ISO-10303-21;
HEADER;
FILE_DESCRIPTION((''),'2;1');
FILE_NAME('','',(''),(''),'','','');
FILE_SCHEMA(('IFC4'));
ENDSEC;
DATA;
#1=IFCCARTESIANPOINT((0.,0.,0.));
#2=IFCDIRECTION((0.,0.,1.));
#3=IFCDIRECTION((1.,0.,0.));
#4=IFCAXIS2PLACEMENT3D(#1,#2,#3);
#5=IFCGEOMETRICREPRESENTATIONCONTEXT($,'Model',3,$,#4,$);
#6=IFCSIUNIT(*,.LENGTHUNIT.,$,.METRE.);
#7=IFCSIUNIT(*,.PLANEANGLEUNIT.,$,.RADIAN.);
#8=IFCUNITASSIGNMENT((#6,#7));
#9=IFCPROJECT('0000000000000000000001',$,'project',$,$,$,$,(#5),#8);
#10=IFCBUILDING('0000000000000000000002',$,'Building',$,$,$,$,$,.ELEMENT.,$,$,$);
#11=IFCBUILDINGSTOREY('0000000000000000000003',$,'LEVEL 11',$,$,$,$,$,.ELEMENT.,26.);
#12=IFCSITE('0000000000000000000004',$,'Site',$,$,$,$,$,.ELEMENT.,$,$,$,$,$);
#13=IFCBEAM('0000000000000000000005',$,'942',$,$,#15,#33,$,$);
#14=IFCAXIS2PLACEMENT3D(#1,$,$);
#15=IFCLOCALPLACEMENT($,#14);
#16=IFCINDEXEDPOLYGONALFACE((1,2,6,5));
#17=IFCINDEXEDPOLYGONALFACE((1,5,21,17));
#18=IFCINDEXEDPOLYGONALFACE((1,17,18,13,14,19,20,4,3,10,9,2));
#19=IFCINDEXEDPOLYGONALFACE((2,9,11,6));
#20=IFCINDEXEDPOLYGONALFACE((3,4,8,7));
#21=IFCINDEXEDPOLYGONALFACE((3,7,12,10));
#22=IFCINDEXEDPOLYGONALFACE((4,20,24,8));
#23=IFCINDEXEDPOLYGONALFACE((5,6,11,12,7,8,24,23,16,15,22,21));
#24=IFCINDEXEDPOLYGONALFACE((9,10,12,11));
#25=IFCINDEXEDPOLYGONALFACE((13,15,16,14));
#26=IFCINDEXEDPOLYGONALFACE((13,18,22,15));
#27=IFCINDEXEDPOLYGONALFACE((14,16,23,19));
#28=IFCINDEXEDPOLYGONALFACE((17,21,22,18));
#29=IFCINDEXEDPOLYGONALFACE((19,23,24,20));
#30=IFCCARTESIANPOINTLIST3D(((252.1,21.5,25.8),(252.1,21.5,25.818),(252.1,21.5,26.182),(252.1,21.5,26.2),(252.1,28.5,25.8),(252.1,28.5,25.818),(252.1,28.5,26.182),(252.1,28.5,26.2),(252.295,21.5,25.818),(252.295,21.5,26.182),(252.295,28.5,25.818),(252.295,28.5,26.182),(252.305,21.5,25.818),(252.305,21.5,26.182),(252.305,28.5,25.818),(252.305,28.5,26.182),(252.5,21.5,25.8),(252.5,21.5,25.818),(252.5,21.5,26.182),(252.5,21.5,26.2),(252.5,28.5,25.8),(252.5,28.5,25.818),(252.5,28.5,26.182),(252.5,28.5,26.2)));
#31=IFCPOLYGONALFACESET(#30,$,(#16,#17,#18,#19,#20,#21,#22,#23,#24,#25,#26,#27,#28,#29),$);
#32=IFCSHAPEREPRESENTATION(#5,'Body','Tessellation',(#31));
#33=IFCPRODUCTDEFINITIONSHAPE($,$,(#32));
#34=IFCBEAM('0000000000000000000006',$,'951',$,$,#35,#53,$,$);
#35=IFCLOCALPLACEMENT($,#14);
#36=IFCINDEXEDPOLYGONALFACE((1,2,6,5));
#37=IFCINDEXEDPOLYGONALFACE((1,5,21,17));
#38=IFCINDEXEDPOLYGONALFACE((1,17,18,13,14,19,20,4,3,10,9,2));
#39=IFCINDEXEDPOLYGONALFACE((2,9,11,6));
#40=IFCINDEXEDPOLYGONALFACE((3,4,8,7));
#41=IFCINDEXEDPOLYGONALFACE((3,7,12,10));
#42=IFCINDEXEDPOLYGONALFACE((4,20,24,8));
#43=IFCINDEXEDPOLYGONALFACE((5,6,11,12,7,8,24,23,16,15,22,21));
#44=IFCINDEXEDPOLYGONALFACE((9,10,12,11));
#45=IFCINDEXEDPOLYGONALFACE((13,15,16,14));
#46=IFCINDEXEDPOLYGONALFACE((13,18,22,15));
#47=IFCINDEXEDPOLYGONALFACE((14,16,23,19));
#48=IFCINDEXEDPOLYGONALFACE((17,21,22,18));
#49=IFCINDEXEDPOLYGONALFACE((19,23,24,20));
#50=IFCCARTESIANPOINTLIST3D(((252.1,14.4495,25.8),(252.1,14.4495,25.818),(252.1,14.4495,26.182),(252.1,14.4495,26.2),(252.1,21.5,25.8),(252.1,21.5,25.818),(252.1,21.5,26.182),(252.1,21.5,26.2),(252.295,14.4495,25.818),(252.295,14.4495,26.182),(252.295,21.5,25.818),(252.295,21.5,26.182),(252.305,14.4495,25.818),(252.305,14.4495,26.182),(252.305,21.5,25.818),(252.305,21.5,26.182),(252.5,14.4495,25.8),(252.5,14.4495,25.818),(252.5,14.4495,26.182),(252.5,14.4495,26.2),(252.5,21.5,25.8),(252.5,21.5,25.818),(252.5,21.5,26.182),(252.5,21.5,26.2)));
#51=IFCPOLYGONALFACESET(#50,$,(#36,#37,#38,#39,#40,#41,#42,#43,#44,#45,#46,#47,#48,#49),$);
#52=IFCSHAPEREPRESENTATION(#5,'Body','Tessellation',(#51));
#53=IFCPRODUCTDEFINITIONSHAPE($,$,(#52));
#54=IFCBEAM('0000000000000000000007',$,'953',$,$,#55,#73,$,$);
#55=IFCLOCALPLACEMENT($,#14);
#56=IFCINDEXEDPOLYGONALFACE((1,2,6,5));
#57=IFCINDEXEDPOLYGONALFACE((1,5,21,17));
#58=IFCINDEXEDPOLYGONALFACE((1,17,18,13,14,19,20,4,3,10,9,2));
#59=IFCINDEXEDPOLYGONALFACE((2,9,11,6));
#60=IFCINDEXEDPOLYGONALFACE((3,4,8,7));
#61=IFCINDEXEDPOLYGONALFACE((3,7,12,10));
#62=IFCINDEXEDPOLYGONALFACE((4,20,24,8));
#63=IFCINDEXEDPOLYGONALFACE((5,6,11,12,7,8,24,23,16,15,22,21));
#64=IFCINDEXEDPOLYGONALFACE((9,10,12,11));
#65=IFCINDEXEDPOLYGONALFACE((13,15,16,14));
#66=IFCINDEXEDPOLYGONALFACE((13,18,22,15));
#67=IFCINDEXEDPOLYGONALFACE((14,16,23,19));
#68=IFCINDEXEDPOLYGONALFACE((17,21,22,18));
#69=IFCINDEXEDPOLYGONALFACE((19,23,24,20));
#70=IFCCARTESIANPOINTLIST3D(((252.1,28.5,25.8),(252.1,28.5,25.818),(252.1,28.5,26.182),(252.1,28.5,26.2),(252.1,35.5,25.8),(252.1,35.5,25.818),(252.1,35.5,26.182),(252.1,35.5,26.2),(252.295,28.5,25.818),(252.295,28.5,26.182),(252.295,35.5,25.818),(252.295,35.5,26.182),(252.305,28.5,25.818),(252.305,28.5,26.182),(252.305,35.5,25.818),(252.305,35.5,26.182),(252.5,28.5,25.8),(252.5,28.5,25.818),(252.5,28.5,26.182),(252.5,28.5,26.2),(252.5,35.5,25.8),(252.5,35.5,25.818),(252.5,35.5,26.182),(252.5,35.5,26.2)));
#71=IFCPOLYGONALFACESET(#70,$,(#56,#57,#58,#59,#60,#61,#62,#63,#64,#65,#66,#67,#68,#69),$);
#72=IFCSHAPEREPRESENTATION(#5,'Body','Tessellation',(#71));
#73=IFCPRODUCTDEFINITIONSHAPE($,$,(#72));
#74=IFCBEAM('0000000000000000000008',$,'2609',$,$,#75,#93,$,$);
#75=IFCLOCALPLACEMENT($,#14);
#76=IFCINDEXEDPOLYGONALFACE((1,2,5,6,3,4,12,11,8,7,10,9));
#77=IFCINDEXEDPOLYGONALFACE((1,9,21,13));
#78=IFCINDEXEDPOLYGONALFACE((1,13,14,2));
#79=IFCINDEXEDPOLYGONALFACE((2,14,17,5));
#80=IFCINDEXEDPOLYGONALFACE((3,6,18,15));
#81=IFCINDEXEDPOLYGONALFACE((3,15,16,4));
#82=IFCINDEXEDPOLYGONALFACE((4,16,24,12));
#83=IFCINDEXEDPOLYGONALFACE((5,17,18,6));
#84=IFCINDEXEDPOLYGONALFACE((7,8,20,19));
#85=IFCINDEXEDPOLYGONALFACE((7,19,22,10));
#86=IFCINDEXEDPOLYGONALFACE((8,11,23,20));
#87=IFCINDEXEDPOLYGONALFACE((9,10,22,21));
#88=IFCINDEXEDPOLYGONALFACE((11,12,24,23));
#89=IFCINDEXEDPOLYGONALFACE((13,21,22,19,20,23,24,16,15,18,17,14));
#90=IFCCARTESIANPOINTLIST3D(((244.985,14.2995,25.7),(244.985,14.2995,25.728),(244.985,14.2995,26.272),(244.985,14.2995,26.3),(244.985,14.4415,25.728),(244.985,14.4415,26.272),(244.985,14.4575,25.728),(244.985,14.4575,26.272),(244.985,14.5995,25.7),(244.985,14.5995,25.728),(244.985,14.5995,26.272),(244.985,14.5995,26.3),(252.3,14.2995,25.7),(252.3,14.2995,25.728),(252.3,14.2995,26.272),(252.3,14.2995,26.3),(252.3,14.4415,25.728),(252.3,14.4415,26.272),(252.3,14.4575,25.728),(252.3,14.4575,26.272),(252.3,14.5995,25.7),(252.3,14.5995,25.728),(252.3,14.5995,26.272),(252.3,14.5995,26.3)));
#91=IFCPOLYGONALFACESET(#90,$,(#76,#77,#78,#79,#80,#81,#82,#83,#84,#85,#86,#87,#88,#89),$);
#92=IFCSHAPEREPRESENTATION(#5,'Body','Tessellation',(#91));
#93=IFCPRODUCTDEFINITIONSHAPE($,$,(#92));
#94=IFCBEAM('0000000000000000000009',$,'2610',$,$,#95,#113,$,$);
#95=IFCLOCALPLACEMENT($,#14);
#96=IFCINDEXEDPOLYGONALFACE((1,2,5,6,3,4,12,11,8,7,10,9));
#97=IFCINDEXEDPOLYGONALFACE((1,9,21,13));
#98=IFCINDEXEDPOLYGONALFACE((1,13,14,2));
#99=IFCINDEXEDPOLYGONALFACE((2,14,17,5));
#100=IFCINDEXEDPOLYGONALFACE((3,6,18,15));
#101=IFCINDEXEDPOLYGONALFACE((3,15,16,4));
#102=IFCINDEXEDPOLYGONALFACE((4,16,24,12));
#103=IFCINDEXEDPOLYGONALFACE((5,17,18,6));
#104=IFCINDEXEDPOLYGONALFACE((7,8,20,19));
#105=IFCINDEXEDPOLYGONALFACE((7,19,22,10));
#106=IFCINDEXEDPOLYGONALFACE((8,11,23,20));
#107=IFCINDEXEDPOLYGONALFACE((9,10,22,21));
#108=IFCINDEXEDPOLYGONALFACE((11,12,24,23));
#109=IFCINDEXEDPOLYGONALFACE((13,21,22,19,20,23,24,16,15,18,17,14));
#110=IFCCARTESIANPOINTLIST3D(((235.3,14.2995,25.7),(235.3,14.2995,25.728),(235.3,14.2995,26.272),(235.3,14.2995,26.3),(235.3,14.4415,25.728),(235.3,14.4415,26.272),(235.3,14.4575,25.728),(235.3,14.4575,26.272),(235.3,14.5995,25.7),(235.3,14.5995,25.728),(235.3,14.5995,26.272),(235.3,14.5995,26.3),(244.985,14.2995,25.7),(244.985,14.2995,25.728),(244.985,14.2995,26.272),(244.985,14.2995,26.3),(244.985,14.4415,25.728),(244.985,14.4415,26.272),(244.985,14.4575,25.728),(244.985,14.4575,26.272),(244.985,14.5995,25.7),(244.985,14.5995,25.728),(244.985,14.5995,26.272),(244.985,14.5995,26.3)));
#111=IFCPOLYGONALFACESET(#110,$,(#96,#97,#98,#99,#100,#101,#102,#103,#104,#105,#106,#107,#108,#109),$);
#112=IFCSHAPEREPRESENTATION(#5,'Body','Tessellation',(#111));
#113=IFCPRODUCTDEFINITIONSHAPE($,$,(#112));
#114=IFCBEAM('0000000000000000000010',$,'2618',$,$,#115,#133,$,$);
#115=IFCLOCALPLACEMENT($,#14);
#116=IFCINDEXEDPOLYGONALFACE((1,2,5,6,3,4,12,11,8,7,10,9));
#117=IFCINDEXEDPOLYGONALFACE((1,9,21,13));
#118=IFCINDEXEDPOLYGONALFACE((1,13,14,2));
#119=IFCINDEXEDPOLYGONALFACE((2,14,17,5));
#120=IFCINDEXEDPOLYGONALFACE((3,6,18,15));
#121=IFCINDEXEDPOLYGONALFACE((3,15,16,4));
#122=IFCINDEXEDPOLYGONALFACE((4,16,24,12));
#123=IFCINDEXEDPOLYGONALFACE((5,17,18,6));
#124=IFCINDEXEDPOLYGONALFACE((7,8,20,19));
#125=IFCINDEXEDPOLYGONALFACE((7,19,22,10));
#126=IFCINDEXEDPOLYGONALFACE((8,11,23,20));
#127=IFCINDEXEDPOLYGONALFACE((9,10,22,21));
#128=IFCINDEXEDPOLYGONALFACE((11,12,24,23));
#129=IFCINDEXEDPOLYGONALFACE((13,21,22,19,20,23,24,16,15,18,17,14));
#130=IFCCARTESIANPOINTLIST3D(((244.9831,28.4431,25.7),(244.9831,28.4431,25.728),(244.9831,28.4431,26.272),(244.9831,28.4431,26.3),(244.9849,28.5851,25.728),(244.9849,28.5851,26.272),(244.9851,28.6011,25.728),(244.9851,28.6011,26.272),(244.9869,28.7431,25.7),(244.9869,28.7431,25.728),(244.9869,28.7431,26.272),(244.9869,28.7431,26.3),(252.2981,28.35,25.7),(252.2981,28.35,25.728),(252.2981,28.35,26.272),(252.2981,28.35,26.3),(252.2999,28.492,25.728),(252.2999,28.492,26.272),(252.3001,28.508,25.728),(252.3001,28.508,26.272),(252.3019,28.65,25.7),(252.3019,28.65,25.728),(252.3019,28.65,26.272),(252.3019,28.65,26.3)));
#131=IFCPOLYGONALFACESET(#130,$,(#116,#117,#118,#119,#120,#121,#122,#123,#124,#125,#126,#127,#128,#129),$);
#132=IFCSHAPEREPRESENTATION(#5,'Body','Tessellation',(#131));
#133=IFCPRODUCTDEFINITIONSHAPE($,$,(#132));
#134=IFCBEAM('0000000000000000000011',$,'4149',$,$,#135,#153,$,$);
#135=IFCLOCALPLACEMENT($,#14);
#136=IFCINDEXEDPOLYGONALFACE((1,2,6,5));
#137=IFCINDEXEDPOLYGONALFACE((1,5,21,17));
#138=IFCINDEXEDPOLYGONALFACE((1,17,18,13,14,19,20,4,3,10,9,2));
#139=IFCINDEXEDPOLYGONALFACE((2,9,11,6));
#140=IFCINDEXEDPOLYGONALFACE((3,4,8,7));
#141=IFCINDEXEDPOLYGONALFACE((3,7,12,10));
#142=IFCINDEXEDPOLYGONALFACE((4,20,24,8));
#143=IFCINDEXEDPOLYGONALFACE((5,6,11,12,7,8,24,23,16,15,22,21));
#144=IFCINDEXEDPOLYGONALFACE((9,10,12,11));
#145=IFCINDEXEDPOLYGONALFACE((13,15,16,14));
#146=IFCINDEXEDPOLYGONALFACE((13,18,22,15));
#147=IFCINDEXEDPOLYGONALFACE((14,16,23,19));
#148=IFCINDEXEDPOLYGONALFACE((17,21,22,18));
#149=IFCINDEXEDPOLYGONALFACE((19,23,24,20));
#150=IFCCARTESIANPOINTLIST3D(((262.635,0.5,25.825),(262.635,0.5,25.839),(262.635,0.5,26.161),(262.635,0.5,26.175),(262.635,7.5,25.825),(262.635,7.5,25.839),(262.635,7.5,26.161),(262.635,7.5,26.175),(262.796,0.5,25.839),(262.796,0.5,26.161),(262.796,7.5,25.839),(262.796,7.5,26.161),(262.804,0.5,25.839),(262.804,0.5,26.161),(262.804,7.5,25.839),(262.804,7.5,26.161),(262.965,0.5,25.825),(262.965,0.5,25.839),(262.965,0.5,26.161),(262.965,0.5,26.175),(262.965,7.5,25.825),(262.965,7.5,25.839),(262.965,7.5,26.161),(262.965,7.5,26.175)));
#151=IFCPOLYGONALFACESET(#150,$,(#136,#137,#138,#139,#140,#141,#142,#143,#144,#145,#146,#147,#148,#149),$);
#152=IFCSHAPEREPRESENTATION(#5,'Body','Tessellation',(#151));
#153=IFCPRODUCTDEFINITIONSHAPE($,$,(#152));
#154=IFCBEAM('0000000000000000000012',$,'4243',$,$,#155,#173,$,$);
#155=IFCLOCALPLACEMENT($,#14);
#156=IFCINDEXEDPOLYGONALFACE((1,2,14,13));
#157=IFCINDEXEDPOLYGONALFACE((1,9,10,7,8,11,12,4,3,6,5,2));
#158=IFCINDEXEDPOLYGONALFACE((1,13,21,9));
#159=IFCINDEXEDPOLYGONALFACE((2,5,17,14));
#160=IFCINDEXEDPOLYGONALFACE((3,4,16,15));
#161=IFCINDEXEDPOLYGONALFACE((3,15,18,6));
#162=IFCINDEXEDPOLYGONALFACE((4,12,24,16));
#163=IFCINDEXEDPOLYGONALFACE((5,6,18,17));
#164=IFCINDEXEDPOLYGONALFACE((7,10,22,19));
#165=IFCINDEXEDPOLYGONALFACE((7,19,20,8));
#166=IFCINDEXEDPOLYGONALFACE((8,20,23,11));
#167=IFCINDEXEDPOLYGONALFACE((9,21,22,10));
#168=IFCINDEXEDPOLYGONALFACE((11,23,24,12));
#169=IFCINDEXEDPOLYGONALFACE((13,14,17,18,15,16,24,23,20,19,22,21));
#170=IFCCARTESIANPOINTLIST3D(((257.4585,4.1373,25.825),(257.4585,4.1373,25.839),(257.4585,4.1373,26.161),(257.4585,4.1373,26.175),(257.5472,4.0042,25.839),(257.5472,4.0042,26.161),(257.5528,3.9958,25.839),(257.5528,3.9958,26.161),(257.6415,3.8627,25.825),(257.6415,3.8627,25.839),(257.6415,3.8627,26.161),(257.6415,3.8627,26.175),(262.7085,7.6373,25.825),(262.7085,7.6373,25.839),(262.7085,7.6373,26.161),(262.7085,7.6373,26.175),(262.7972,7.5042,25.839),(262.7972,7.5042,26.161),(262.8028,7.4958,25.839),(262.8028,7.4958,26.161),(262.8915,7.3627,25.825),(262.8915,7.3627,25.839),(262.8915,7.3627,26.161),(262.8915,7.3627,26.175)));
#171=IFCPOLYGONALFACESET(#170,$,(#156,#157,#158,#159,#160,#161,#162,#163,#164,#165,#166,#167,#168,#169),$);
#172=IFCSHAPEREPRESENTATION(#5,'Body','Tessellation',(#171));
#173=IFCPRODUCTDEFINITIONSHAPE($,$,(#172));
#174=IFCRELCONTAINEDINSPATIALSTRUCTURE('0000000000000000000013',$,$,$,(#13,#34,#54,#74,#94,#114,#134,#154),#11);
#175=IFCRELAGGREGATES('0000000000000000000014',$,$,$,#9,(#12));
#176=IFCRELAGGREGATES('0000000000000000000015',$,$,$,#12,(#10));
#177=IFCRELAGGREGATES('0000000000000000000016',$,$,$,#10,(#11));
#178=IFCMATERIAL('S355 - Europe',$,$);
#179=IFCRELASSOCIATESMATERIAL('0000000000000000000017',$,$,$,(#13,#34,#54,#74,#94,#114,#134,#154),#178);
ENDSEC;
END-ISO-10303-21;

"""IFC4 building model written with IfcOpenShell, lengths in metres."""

from ifc_helpers import new_model, si_unit, frame, origin_with_axes, origin_2d_with_axis, place, context, project, spatial, i_section, extrude, material, material_profile, profile_set, profile_usage, element, save


model = new_model("IFC4")

# Units and contexts
model_context = context("Model", 3, world=origin_with_axes())
ifc_project = project(units=[si_unit("LENGTHUNIT", "METRE"), si_unit("PLANEANGLEUNIT", "RADIAN")], contexts=[model_context])

# Site, building, storey
site = spatial("IfcSite", under=ifc_project, Name="Site", CompositionType="ELEMENT")
building = spatial("IfcBuilding", under=site, Name="Building", CompositionType="ELEMENT")
storey = spatial("IfcBuildingStorey", under=building, Name="LEVEL 11", CompositionType="ELEMENT", Elevation=26.0)

# Shared definitions
ifc_material = material(Name="S355 - Europe")

# Beams
ifc_material_profile_1 = material_profile(ifc_material, i_section(OverallWidth=0.4, OverallDepth=0.4, WebThickness=0.01, FlangeThickness=0.018, at=origin_2d_with_axis()))
ifc_profile_set_1 = profile_set([ifc_material_profile_1])
ifc_profile_usage_1 = profile_usage(ifc_profile_set_1, cardinal=10)
beam_1_placement = place(None, frame((252.3, 21.5, 26.0), z_axis=(0.0, 1.0, 0.0), x_axis=(-1.0, 0.0, 0.0)))
element("IfcBeam", 1, at=beam_1_placement, inside=storey, material=ifc_profile_usage_1, Name="942", context=model_context, shape_type="SweptSolid", body=[
    extrude(i_section(OverallWidth=0.4, OverallDepth=0.4, WebThickness=0.01, FlangeThickness=0.018, at=origin_2d_with_axis()), origin_with_axes(), (0.0, 0.0, 1.0), 7.0),
])
ifc_material_profile_2 = material_profile(ifc_material, i_section(OverallWidth=0.4, OverallDepth=0.4, WebThickness=0.01, FlangeThickness=0.018, at=origin_2d_with_axis()))
ifc_profile_set_2 = profile_set([ifc_material_profile_2])
ifc_profile_usage_2 = profile_usage(ifc_profile_set_2, cardinal=10)
beam_2_placement = place(None, frame((252.3, 14.4495, 26.0), z_axis=(0.0, 1.0, 0.0), x_axis=(-1.0, 0.0, 0.0)))
element("IfcBeam", 2, at=beam_2_placement, inside=storey, material=ifc_profile_usage_2, Name="951", context=model_context, shape_type="SweptSolid", body=[
    extrude(i_section(OverallWidth=0.4, OverallDepth=0.4, WebThickness=0.01, FlangeThickness=0.018, at=origin_2d_with_axis()), origin_with_axes(), (0.0, 0.0, 1.0), 7.0505),
])
ifc_material_profile_3 = material_profile(ifc_material, i_section(OverallWidth=0.4, OverallDepth=0.4, WebThickness=0.01, FlangeThickness=0.018, at=origin_2d_with_axis()))
ifc_profile_set_3 = profile_set([ifc_material_profile_3])
ifc_profile_usage_3 = profile_usage(ifc_profile_set_3, cardinal=10)
beam_3_placement = place(None, frame((252.3, 28.5, 26.0), z_axis=(0.0, 1.0, 0.0), x_axis=(-1.0, 0.0, 0.0)))
element("IfcBeam", 3, at=beam_3_placement, inside=storey, material=ifc_profile_usage_3, Name="953", context=model_context, shape_type="SweptSolid", body=[
    extrude(i_section(OverallWidth=0.4, OverallDepth=0.4, WebThickness=0.01, FlangeThickness=0.018, at=origin_2d_with_axis()), origin_with_axes(), (0.0, 0.0, 1.0), 7.0),
])
ifc_material_profile_4 = material_profile(ifc_material, i_section(OverallWidth=0.3, OverallDepth=0.6, WebThickness=0.016, FlangeThickness=0.028, at=origin_2d_with_axis()))
ifc_profile_set_4 = profile_set([ifc_material_profile_4])
ifc_profile_usage_4 = profile_usage(ifc_profile_set_4, cardinal=10)
beam_4_placement = place(None, frame((252.3, 14.4495, 26.0), z_axis=(-1.0, 0.0, 0.0), x_axis=(0.0, -1.0, 0.0)))
element("IfcBeam", 4, at=beam_4_placement, inside=storey, material=ifc_profile_usage_4, Name="2609", context=model_context, shape_type="SweptSolid", body=[
    extrude(i_section(OverallWidth=0.3, OverallDepth=0.6, WebThickness=0.016, FlangeThickness=0.028, at=origin_2d_with_axis()), origin_with_axes(), (0.0, 0.0, 1.0), 7.315),
])
ifc_material_profile_5 = material_profile(ifc_material, i_section(OverallWidth=0.3, OverallDepth=0.6, WebThickness=0.016, FlangeThickness=0.028, at=origin_2d_with_axis()))
ifc_profile_set_5 = profile_set([ifc_material_profile_5])
ifc_profile_usage_5 = profile_usage(ifc_profile_set_5, cardinal=10)
beam_5_placement = place(None, frame((244.985, 14.4495, 26.0), z_axis=(-1.0, 0.0, 0.0), x_axis=(0.0, -1.0, 0.0)))
element("IfcBeam", 5, at=beam_5_placement, inside=storey, material=ifc_profile_usage_5, Name="2610", context=model_context, shape_type="SweptSolid", body=[
    extrude(i_section(OverallWidth=0.3, OverallDepth=0.6, WebThickness=0.016, FlangeThickness=0.028, at=origin_2d_with_axis()), origin_with_axes(), (0.0, 0.0, 1.0), 9.685),
])
ifc_material_profile_6 = material_profile(ifc_material, i_section(OverallWidth=0.3, OverallDepth=0.6, WebThickness=0.016, FlangeThickness=0.028, at=origin_2d_with_axis()))
ifc_profile_set_6 = profile_set([ifc_material_profile_6])
ifc_profile_usage_6 = profile_usage(ifc_profile_set_6, cardinal=10)
beam_6_placement = place(None, frame((252.3, 28.5, 26.0), z_axis=(-0.999919, 0.012726, 0.0), x_axis=(-0.012726, -0.999919, 0.0)))
element("IfcBeam", 6, at=beam_6_placement, inside=storey, material=ifc_profile_usage_6, Name="2618", context=model_context, shape_type="SweptSolid", body=[
    extrude(i_section(OverallWidth=0.3, OverallDepth=0.6, WebThickness=0.016, FlangeThickness=0.028, at=origin_2d_with_axis()), origin_with_axes(), (0.0, 0.0, 1.0), 7.3156),
])
ifc_material_profile_7 = material_profile(ifc_material, i_section(OverallWidth=0.33, OverallDepth=0.35, WebThickness=0.008, FlangeThickness=0.014, at=origin_2d_with_axis()))
ifc_profile_set_7 = profile_set([ifc_material_profile_7])
ifc_profile_usage_7 = profile_usage(ifc_profile_set_7, cardinal=10)
beam_7_placement = place(None, frame((262.8, 7.5, 26.0), z_axis=(0.0, -1.0, 0.0), x_axis=(1.0, 0.0, 0.0)))
element("IfcBeam", 7, at=beam_7_placement, inside=storey, material=ifc_profile_usage_7, Name="4149", context=model_context, shape_type="SweptSolid", body=[
    extrude(i_section(OverallWidth=0.33, OverallDepth=0.35, WebThickness=0.008, FlangeThickness=0.014, at=origin_2d_with_axis()), origin_with_axes(), (0.0, 0.0, 1.0), 7.0),
])
ifc_material_profile_8 = material_profile(ifc_material, i_section(OverallWidth=0.33, OverallDepth=0.35, WebThickness=0.01, FlangeThickness=0.014, at=origin_2d_with_axis()))
ifc_profile_set_8 = profile_set([ifc_material_profile_8])
ifc_profile_usage_8 = profile_usage(ifc_profile_set_8, cardinal=10)
beam_8_placement = place(None, frame((262.8, 7.5, 26.0), z_axis=(-0.83205, -0.5547, 0.0), x_axis=(0.5547, -0.83205, 0.0)))
element("IfcBeam", 8, at=beam_8_placement, inside=storey, material=ifc_profile_usage_8, Name="4243", context=model_context, shape_type="SweptSolid", body=[
    extrude(i_section(OverallWidth=0.33, OverallDepth=0.35, WebThickness=0.01, FlangeThickness=0.014, at=origin_2d_with_axis()), origin_with_axes(), (0.0, 0.0, 1.0), 6.3097),
])

save(model, "model.ifc")
